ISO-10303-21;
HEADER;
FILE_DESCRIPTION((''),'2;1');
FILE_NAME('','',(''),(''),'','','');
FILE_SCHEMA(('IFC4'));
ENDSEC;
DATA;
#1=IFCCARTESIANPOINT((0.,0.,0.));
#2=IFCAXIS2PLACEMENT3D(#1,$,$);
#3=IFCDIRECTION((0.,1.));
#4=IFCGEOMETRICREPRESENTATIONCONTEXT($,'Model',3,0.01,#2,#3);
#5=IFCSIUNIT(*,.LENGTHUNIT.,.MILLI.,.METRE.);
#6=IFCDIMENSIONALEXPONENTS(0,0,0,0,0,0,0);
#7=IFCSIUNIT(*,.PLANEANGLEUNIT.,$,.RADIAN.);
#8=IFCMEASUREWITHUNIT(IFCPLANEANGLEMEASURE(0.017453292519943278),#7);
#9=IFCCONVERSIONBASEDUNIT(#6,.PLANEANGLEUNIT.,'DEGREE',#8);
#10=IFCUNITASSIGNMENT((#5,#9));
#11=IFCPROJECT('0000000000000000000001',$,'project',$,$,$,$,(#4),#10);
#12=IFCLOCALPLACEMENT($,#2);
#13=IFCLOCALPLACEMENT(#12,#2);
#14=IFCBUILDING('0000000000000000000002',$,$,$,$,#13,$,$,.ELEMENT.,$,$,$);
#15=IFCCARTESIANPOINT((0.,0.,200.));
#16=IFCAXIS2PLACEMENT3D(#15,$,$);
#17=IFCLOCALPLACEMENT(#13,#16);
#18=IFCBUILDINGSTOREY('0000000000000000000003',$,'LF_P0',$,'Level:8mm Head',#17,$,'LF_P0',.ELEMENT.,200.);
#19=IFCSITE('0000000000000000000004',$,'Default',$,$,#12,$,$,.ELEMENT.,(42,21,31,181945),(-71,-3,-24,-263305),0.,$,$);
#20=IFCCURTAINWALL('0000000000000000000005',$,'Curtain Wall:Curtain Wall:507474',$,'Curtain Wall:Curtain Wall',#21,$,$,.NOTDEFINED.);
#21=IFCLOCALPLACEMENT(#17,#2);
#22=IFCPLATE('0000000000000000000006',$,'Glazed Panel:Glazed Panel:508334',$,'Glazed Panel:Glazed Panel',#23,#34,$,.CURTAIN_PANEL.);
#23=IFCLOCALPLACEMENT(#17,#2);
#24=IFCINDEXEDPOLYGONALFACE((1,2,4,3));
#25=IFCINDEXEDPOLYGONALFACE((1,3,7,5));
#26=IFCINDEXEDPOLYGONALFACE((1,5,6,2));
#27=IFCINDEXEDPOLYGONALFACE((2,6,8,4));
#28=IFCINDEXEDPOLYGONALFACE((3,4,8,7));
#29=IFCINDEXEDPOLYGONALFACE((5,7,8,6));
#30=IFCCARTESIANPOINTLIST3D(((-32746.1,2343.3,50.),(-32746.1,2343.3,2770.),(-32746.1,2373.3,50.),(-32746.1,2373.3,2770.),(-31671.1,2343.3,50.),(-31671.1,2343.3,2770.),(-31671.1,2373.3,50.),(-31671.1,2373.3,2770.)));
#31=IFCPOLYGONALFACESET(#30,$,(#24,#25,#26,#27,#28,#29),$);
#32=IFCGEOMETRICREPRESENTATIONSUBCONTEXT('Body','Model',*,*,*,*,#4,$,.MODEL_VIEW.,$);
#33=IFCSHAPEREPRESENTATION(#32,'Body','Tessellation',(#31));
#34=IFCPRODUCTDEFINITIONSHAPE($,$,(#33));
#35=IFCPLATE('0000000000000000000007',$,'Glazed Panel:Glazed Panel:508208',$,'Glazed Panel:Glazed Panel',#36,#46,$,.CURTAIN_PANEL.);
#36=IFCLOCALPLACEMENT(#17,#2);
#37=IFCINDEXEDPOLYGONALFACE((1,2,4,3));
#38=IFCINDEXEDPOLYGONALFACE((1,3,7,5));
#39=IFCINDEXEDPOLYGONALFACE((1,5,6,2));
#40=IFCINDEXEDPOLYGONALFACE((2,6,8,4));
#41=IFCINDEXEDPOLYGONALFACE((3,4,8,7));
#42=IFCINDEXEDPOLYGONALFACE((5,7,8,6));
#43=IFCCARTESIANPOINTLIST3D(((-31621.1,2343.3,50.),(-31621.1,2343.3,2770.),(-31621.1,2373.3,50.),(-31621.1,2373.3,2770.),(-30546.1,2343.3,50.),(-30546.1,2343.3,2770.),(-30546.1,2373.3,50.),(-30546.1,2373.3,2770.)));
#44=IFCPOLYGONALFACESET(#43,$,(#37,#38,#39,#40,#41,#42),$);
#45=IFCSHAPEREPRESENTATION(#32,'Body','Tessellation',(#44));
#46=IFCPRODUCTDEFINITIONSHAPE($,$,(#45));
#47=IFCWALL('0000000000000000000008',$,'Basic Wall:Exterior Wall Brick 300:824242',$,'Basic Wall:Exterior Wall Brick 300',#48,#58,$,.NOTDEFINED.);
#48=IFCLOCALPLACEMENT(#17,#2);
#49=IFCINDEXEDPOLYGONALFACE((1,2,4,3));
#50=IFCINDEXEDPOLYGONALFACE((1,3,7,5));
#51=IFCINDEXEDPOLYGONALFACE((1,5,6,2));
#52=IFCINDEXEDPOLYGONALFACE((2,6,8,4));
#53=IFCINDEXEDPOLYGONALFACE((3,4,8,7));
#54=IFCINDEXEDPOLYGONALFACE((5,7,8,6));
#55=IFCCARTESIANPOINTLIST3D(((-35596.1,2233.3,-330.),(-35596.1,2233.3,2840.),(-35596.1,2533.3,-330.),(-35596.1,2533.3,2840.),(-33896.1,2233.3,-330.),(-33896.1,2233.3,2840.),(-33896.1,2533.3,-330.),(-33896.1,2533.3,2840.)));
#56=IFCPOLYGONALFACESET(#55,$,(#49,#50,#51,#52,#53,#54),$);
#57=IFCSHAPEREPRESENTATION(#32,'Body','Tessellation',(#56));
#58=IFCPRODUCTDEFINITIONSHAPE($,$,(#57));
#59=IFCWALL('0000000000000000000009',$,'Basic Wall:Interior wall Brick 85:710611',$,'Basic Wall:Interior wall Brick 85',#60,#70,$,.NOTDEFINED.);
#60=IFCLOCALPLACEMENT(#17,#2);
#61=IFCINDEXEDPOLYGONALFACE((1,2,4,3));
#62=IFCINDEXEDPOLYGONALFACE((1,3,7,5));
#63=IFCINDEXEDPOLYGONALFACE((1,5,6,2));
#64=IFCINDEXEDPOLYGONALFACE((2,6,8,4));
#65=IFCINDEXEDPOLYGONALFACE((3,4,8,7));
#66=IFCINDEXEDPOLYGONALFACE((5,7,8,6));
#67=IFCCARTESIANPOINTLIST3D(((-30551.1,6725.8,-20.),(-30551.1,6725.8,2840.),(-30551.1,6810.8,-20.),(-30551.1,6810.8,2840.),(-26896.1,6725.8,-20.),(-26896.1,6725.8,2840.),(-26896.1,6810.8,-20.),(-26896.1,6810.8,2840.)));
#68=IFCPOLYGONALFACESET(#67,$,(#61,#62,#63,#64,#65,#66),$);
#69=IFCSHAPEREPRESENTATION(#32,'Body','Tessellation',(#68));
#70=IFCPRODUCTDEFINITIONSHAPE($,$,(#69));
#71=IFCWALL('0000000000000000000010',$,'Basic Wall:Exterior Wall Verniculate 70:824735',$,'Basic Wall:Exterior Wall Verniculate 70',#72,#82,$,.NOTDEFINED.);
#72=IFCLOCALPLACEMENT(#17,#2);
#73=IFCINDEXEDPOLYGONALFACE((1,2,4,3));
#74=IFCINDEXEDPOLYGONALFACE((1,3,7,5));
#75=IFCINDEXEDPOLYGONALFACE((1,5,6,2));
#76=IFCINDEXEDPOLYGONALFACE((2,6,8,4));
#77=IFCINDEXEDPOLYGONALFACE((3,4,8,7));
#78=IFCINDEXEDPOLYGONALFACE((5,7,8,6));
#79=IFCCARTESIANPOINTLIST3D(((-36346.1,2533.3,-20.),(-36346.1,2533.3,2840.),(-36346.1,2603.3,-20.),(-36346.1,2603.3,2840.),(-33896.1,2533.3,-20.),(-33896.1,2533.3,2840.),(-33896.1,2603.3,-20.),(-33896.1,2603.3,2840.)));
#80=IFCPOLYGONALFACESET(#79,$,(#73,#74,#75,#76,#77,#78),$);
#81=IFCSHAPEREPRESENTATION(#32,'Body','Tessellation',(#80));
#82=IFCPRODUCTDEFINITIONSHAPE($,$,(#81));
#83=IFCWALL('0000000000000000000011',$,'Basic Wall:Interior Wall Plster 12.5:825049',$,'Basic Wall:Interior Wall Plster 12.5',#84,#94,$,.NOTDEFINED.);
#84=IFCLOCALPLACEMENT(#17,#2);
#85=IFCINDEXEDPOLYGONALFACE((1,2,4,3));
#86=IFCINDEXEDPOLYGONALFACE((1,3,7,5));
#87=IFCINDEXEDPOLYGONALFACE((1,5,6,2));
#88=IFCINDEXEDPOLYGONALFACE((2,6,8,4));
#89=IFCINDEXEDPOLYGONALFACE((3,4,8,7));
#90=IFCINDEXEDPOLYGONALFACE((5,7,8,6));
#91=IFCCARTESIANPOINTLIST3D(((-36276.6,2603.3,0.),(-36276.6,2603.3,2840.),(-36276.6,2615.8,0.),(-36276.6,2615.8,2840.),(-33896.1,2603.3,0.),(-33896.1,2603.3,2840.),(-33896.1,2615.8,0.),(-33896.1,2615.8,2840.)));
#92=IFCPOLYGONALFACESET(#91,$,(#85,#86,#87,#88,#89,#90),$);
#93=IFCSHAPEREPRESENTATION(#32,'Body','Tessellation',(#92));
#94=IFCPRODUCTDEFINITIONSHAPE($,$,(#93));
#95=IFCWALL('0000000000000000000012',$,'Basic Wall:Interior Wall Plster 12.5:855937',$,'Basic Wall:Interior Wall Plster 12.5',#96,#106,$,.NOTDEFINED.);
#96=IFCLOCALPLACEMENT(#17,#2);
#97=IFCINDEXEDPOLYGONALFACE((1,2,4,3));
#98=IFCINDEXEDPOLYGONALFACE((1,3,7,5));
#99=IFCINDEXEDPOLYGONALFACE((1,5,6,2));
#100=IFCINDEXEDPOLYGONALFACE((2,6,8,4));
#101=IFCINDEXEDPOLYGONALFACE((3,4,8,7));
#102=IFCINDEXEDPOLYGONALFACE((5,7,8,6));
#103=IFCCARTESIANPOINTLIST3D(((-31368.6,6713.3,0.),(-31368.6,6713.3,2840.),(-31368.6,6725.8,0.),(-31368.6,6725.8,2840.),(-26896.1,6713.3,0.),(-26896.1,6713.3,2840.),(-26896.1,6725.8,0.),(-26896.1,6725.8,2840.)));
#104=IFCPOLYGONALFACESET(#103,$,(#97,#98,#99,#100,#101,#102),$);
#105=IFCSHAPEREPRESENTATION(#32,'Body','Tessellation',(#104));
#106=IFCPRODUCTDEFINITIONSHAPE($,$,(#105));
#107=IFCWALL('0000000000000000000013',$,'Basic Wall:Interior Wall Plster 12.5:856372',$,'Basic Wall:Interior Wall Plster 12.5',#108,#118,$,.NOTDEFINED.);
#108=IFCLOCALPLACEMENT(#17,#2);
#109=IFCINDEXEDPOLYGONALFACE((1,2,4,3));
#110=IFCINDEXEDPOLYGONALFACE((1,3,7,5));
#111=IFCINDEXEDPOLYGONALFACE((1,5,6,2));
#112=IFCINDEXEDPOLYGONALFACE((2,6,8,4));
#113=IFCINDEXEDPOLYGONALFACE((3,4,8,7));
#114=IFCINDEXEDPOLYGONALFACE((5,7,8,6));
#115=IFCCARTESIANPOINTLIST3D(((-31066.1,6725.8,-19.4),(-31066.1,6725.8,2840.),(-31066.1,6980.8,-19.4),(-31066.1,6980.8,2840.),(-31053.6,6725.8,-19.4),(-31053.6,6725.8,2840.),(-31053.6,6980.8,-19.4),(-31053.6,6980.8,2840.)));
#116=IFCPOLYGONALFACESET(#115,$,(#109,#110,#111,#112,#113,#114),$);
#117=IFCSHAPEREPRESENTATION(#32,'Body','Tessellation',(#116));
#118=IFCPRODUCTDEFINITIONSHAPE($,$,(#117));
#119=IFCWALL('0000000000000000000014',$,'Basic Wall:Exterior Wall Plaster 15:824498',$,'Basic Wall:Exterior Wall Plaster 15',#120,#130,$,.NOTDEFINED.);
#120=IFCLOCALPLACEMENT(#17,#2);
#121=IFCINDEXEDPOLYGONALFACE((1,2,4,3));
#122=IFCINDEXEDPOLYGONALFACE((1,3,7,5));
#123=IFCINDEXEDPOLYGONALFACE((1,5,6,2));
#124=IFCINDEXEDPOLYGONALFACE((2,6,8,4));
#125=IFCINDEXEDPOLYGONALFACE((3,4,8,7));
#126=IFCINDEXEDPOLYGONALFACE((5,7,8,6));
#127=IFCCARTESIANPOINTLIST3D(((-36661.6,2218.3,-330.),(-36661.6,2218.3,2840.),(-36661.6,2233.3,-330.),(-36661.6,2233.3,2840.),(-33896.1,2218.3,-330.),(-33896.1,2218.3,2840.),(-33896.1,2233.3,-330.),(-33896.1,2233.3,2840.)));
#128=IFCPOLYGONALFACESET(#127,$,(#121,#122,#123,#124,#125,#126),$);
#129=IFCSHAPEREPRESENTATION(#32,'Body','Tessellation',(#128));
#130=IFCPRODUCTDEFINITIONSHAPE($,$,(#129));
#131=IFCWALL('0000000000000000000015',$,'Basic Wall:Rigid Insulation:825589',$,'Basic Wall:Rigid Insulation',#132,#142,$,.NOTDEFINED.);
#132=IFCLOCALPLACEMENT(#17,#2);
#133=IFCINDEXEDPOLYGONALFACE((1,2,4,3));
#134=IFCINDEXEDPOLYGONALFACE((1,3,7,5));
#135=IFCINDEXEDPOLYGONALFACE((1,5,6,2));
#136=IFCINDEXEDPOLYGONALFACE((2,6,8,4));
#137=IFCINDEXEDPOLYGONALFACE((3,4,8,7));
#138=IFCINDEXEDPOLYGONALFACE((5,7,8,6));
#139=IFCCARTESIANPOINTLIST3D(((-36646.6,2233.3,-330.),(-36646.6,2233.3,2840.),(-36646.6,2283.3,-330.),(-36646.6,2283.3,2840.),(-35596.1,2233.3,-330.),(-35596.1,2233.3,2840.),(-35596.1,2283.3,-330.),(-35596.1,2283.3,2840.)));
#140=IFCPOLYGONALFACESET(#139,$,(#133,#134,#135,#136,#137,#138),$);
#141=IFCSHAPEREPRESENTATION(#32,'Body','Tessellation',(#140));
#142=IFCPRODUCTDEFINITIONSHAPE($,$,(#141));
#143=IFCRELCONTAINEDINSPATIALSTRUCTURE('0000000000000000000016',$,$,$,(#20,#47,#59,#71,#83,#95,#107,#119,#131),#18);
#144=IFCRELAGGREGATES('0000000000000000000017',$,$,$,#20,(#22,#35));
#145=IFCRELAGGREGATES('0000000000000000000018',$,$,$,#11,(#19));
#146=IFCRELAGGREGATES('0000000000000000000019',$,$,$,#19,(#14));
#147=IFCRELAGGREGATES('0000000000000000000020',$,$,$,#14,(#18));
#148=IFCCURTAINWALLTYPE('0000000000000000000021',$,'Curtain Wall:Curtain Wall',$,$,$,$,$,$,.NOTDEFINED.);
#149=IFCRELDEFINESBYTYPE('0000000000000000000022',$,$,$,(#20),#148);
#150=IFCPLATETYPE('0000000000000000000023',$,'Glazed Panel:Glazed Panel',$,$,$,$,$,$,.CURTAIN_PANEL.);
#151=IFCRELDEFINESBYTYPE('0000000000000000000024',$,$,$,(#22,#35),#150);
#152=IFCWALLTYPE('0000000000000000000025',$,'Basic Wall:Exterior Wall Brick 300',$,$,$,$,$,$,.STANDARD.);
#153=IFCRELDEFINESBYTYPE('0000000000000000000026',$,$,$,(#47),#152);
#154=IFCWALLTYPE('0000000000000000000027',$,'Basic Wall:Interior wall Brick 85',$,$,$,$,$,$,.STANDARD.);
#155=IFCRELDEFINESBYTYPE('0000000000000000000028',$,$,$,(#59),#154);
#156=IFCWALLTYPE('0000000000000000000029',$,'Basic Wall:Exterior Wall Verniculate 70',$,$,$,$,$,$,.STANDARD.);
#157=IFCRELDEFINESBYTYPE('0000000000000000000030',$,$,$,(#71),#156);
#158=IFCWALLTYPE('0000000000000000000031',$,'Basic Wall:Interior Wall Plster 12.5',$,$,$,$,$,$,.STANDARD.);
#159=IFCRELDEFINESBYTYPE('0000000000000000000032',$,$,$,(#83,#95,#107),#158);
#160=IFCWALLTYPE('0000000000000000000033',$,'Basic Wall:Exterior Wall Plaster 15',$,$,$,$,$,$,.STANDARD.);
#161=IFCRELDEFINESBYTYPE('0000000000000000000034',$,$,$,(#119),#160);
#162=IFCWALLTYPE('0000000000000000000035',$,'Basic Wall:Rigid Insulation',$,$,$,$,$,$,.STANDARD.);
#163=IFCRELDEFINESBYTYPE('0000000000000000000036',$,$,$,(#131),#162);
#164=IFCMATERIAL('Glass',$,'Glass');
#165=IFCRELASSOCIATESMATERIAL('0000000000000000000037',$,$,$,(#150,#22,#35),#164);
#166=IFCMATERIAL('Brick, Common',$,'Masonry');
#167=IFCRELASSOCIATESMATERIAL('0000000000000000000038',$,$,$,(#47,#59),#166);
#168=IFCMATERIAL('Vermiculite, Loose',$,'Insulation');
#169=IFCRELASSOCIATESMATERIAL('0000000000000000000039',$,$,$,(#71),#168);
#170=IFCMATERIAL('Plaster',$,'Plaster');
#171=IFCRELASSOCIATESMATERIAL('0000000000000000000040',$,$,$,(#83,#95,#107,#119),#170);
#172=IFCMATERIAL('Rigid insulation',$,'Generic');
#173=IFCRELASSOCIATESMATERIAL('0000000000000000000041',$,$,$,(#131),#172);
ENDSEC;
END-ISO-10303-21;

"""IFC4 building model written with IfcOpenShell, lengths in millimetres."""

from ifc_helpers import new_model, entity, si_unit, converted_unit, direction, frame, origin, place, context, subcontext, project, spatial, indexed_curve, outline, extrude, source, transform, mapped, material, type_object, type_shapes, element, aggregate, save


model = new_model("IFC4")

# Units and contexts
model_context = context("Model", 3, precision=0.01, world=origin(), true_north=direction((0.0, 1.0)))
body_context = subcontext(model_context, "Body", "Model", "MODEL_VIEW")
ifc_project = project(units=[si_unit("LENGTHUNIT", "METRE", prefix="MILLI"), converted_unit("PLANEANGLEUNIT", "DEGREE", entity("IfcPlaneAngleMeasure", 0.017453292519943278), si_unit("PLANEANGLEUNIT", "RADIAN"), dimensions=[0, 0, 0, 0, 0, 0, 0])], contexts=[model_context])

# Site, building, storey
site_placement = place(None, origin())
site = spatial("IfcSite", under=ifc_project, at=site_placement, Name="Default", CompositionType="ELEMENT", RefLatitude=(42, 21, 31, 181945), RefLongitude=(-71, -3, -24, -263305), RefElevation=0.0)
building_placement = place(site_placement, origin())
building = spatial("IfcBuilding", under=site, at=building_placement, CompositionType="ELEMENT")
storey_placement = place(building_placement, frame((0.0, 0.0, 200.0)))
storey = spatial("IfcBuildingStorey", under=building, at=storey_placement, Name="LF_P0", ObjectType="Level:8mm Head", LongName="LF_P0", CompositionType="ELEMENT", Elevation=200.0)

# Curtain wall, plates
curtain_wall_type = type_object("IfcCurtainWallType", Name="Curtain Wall:Curtain Wall", PredefinedType="NOTDEFINED")
curtain_wall_placement = place(storey_placement, frame((0.0, 0.0, -200.0)))
curtain_wall = element("IfcCurtainWall", 1, at=curtain_wall_placement, inside=storey, type_object=curtain_wall_type, Name="Curtain Wall:Curtain Wall:507474", ObjectType="Curtain Wall:Curtain Wall", PredefinedType="NOTDEFINED")
ifc_material_1 = material(Name="Glass", Category="Glass")
plate_type_1 = type_object("IfcPlateType", Name="Glazed Panel:Glazed Panel", PredefinedType="CURTAIN_PANEL", material=ifc_material_1)
shared_shape_1 = source(origin(), body_context, "Body", "SweptSolid", [
    extrude(outline(indexed_curve([(-15.0, -537.5), (15.0, -537.5), (15.0, 537.5), (-15.0, 537.5), (-15.0, -537.5)], self_intersect=False)), frame((0.0, 0.0, 0.0), z_axis=(0.0, 0.0, 1.0), x_axis=(0.0, 1.0, 0.0)), (0.0, 0.0, 1.0), 2720.0),
])
type_shapes(plate_type_1, [shared_shape_1])
plate_1_placement = place(curtain_wall_placement, frame((-32208.6, 2358.3, 250.0)))
plate_1 = element("IfcPlate", 2, at=plate_1_placement, type_object=plate_type_1, material=ifc_material_1, Name="Glazed Panel:Glazed Panel:508334", ObjectType="Glazed Panel:Glazed Panel", PredefinedType="CURTAIN_PANEL", context=body_context, shape_type="MappedRepresentation", body=[
    mapped(shared_shape_1, transform((0.0, 0.0, 0.0), scale=1.0)),
])
plate_2_placement = place(curtain_wall_placement, frame((-31083.6, 2358.3, 250.0)))
plate_2 = element("IfcPlate", 3, at=plate_2_placement, type_object=plate_type_1, material=ifc_material_1, Name="Glazed Panel:Glazed Panel:508208", ObjectType="Glazed Panel:Glazed Panel", PredefinedType="CURTAIN_PANEL", context=body_context, shape_type="MappedRepresentation", body=[
    mapped(shared_shape_1, transform((0.0, 0.0, 0.0), scale=1.0)),
])
aggregate(curtain_wall, [plate_1, plate_2])

# Walls
ifc_material_2 = material(Name="Brick, Common", Category="Masonry")
wall_type_1 = type_object("IfcWallType", Name="Basic Wall:Exterior Wall Brick 300", PredefinedType="STANDARD")
wall_1_placement = place(storey_placement, frame((-33896.1, 2383.3, -330.0), z_axis=(0.0, 0.0, 1.0), x_axis=(-1.0, 0.0, 0.0)))
element("IfcWall", 4, at=wall_1_placement, inside=storey, type_object=wall_type_1, material=ifc_material_2, Name="Basic Wall:Exterior Wall Brick 300:824242", ObjectType="Basic Wall:Exterior Wall Brick 300", PredefinedType="NOTDEFINED", context=body_context, shape_type="SweptSolid", body=[
    extrude(outline(indexed_curve([(1700.0, 150.0), (0.0, 150.0), (0.0, -150.0), (1700.0, -150.0), (1700.0, 150.0)], self_intersect=False)), origin(), (0.0, 0.0, 1.0), 3170.0),
])
wall_type_2 = type_object("IfcWallType", Name="Basic Wall:Interior wall Brick 85", PredefinedType="STANDARD")
wall_2_placement = place(storey_placement, frame((-30551.1, 6768.3, -20.0)))
element("IfcWall", 5, at=wall_2_placement, inside=storey, type_object=wall_type_2, material=ifc_material_2, Name="Basic Wall:Interior wall Brick 85:710611", ObjectType="Basic Wall:Interior wall Brick 85", PredefinedType="NOTDEFINED", context=body_context, shape_type="SweptSolid", body=[
    extrude(outline(indexed_curve([(3655.0, 42.5), (0.0, 42.5), (0.0, -42.5), (3655.0, -42.5), (3655.0, 42.5)], self_intersect=False)), origin(), (0.0, 0.0, 1.0), 2860.0),
])
ifc_material_3 = material(Name="Vermiculite, Loose", Category="Insulation")
wall_type_3 = type_object("IfcWallType", Name="Basic Wall:Exterior Wall Verniculate 70", PredefinedType="STANDARD")
wall_3_placement = place(storey_placement, frame((-33896.1, 2568.3, -20.0), z_axis=(0.0, 0.0, 1.0), x_axis=(-1.0, 0.0, 0.0)))
element("IfcWall", 6, at=wall_3_placement, inside=storey, type_object=wall_type_3, material=ifc_material_3, Name="Basic Wall:Exterior Wall Verniculate 70:824735", ObjectType="Basic Wall:Exterior Wall Verniculate 70", PredefinedType="NOTDEFINED", context=body_context, shape_type="SweptSolid", body=[
    extrude(outline(indexed_curve([(2450.0, 35.0), (0.0, 35.0), (0.0, -35.0), (2450.0, -35.0), (2450.0, 35.0)], self_intersect=False)), origin(), (0.0, 0.0, 1.0), 2860.0),
])
ifc_material_4 = material(Name="Plaster", Category="Plaster")
wall_type_4 = type_object("IfcWallType", Name="Basic Wall:Interior Wall Plster 12.5", PredefinedType="STANDARD")
wall_4_placement = place(storey_placement, frame((-33896.1, 2609.6, 0.0), z_axis=(0.0, 0.0, 1.0), x_axis=(-1.0, 0.0, 0.0)))
element("IfcWall", 7, at=wall_4_placement, inside=storey, type_object=wall_type_4, material=ifc_material_4, Name="Basic Wall:Interior Wall Plster 12.5:825049", ObjectType="Basic Wall:Interior Wall Plster 12.5", PredefinedType="NOTDEFINED", context=body_context, shape_type="SweptSolid", body=[
    extrude(outline(indexed_curve([(2380.5, 6.3), (0.0, 6.3), (0.0, -6.3), (2380.5, -6.3), (2380.5, 6.3)], self_intersect=False)), origin(), (0.0, 0.0, 1.0), 2840.0),
])
wall_5_placement = place(storey_placement, frame((-31368.6, 6719.6, 0.0)))
element("IfcWall", 8, at=wall_5_placement, inside=storey, type_object=wall_type_4, material=ifc_material_4, Name="Basic Wall:Interior Wall Plster 12.5:855937", ObjectType="Basic Wall:Interior Wall Plster 12.5", PredefinedType="NOTDEFINED", context=body_context, shape_type="SweptSolid", body=[
    extrude(outline(indexed_curve([(4472.5, 6.2), (0.0, 6.2), (0.0, -6.2), (4472.5, -6.2), (4472.5, 6.2)], self_intersect=False)), origin(), (0.0, 0.0, 1.0), 2840.0),
])
wall_6_placement = place(storey_placement, frame((-31059.9, 6725.8, -19.4), z_axis=(0.0, 0.0, 1.0), x_axis=(0.0, 1.0, 0.0)))
element("IfcWall", 9, at=wall_6_placement, inside=storey, type_object=wall_type_4, material=ifc_material_4, Name="Basic Wall:Interior Wall Plster 12.5:856372", ObjectType="Basic Wall:Interior Wall Plster 12.5", PredefinedType="NOTDEFINED", context=body_context, shape_type="SweptSolid", body=[
    extrude(outline(indexed_curve([(255.0, 6.2), (0.0, 6.2), (0.0, -6.2), (255.0, -6.2), (255.0, 6.2)], self_intersect=False)), origin(), (0.0, 0.0, 1.0), 2859.4),
])
wall_type_5 = type_object("IfcWallType", Name="Basic Wall:Exterior Wall Plaster 15", PredefinedType="STANDARD")
wall_7_placement = place(storey_placement, frame((-33896.1, 2225.8, -330.0), z_axis=(0.0, 0.0, 1.0), x_axis=(-1.0, 0.0, 0.0)))
element("IfcWall", 10, at=wall_7_placement, inside=storey, type_object=wall_type_5, material=ifc_material_4, Name="Basic Wall:Exterior Wall Plaster 15:824498", ObjectType="Basic Wall:Exterior Wall Plaster 15", PredefinedType="NOTDEFINED", context=body_context, shape_type="SweptSolid", body=[
    extrude(outline(indexed_curve([(2765.5, 7.5), (0.0, 7.5), (0.0, -7.5), (2765.5, -7.5), (2765.5, 7.5)], self_intersect=False)), origin(), (0.0, 0.0, 1.0), 3170.0),
])
ifc_material_5 = material(Name="Rigid insulation", Category="Generic")
wall_type_6 = type_object("IfcWallType", Name="Basic Wall:Rigid Insulation", PredefinedType="STANDARD")
wall_8_placement = place(storey_placement, frame((-35596.1, 2258.3, -330.0), z_axis=(0.0, 0.0, 1.0), x_axis=(-1.0, 0.0, 0.0)))
element("IfcWall", 11, at=wall_8_placement, inside=storey, type_object=wall_type_6, material=ifc_material_5, Name="Basic Wall:Rigid Insulation:825589", ObjectType="Basic Wall:Rigid Insulation", PredefinedType="NOTDEFINED", context=body_context, shape_type="SweptSolid", body=[
    extrude(outline(indexed_curve([(1050.5, 25.0), (0.0, 25.0), (0.0, -25.0), (1050.5, -25.0), (1050.5, 25.0)], self_intersect=False)), origin(), (0.0, 0.0, 1.0), 3170.0),
])

save(model, "model.ifc")
